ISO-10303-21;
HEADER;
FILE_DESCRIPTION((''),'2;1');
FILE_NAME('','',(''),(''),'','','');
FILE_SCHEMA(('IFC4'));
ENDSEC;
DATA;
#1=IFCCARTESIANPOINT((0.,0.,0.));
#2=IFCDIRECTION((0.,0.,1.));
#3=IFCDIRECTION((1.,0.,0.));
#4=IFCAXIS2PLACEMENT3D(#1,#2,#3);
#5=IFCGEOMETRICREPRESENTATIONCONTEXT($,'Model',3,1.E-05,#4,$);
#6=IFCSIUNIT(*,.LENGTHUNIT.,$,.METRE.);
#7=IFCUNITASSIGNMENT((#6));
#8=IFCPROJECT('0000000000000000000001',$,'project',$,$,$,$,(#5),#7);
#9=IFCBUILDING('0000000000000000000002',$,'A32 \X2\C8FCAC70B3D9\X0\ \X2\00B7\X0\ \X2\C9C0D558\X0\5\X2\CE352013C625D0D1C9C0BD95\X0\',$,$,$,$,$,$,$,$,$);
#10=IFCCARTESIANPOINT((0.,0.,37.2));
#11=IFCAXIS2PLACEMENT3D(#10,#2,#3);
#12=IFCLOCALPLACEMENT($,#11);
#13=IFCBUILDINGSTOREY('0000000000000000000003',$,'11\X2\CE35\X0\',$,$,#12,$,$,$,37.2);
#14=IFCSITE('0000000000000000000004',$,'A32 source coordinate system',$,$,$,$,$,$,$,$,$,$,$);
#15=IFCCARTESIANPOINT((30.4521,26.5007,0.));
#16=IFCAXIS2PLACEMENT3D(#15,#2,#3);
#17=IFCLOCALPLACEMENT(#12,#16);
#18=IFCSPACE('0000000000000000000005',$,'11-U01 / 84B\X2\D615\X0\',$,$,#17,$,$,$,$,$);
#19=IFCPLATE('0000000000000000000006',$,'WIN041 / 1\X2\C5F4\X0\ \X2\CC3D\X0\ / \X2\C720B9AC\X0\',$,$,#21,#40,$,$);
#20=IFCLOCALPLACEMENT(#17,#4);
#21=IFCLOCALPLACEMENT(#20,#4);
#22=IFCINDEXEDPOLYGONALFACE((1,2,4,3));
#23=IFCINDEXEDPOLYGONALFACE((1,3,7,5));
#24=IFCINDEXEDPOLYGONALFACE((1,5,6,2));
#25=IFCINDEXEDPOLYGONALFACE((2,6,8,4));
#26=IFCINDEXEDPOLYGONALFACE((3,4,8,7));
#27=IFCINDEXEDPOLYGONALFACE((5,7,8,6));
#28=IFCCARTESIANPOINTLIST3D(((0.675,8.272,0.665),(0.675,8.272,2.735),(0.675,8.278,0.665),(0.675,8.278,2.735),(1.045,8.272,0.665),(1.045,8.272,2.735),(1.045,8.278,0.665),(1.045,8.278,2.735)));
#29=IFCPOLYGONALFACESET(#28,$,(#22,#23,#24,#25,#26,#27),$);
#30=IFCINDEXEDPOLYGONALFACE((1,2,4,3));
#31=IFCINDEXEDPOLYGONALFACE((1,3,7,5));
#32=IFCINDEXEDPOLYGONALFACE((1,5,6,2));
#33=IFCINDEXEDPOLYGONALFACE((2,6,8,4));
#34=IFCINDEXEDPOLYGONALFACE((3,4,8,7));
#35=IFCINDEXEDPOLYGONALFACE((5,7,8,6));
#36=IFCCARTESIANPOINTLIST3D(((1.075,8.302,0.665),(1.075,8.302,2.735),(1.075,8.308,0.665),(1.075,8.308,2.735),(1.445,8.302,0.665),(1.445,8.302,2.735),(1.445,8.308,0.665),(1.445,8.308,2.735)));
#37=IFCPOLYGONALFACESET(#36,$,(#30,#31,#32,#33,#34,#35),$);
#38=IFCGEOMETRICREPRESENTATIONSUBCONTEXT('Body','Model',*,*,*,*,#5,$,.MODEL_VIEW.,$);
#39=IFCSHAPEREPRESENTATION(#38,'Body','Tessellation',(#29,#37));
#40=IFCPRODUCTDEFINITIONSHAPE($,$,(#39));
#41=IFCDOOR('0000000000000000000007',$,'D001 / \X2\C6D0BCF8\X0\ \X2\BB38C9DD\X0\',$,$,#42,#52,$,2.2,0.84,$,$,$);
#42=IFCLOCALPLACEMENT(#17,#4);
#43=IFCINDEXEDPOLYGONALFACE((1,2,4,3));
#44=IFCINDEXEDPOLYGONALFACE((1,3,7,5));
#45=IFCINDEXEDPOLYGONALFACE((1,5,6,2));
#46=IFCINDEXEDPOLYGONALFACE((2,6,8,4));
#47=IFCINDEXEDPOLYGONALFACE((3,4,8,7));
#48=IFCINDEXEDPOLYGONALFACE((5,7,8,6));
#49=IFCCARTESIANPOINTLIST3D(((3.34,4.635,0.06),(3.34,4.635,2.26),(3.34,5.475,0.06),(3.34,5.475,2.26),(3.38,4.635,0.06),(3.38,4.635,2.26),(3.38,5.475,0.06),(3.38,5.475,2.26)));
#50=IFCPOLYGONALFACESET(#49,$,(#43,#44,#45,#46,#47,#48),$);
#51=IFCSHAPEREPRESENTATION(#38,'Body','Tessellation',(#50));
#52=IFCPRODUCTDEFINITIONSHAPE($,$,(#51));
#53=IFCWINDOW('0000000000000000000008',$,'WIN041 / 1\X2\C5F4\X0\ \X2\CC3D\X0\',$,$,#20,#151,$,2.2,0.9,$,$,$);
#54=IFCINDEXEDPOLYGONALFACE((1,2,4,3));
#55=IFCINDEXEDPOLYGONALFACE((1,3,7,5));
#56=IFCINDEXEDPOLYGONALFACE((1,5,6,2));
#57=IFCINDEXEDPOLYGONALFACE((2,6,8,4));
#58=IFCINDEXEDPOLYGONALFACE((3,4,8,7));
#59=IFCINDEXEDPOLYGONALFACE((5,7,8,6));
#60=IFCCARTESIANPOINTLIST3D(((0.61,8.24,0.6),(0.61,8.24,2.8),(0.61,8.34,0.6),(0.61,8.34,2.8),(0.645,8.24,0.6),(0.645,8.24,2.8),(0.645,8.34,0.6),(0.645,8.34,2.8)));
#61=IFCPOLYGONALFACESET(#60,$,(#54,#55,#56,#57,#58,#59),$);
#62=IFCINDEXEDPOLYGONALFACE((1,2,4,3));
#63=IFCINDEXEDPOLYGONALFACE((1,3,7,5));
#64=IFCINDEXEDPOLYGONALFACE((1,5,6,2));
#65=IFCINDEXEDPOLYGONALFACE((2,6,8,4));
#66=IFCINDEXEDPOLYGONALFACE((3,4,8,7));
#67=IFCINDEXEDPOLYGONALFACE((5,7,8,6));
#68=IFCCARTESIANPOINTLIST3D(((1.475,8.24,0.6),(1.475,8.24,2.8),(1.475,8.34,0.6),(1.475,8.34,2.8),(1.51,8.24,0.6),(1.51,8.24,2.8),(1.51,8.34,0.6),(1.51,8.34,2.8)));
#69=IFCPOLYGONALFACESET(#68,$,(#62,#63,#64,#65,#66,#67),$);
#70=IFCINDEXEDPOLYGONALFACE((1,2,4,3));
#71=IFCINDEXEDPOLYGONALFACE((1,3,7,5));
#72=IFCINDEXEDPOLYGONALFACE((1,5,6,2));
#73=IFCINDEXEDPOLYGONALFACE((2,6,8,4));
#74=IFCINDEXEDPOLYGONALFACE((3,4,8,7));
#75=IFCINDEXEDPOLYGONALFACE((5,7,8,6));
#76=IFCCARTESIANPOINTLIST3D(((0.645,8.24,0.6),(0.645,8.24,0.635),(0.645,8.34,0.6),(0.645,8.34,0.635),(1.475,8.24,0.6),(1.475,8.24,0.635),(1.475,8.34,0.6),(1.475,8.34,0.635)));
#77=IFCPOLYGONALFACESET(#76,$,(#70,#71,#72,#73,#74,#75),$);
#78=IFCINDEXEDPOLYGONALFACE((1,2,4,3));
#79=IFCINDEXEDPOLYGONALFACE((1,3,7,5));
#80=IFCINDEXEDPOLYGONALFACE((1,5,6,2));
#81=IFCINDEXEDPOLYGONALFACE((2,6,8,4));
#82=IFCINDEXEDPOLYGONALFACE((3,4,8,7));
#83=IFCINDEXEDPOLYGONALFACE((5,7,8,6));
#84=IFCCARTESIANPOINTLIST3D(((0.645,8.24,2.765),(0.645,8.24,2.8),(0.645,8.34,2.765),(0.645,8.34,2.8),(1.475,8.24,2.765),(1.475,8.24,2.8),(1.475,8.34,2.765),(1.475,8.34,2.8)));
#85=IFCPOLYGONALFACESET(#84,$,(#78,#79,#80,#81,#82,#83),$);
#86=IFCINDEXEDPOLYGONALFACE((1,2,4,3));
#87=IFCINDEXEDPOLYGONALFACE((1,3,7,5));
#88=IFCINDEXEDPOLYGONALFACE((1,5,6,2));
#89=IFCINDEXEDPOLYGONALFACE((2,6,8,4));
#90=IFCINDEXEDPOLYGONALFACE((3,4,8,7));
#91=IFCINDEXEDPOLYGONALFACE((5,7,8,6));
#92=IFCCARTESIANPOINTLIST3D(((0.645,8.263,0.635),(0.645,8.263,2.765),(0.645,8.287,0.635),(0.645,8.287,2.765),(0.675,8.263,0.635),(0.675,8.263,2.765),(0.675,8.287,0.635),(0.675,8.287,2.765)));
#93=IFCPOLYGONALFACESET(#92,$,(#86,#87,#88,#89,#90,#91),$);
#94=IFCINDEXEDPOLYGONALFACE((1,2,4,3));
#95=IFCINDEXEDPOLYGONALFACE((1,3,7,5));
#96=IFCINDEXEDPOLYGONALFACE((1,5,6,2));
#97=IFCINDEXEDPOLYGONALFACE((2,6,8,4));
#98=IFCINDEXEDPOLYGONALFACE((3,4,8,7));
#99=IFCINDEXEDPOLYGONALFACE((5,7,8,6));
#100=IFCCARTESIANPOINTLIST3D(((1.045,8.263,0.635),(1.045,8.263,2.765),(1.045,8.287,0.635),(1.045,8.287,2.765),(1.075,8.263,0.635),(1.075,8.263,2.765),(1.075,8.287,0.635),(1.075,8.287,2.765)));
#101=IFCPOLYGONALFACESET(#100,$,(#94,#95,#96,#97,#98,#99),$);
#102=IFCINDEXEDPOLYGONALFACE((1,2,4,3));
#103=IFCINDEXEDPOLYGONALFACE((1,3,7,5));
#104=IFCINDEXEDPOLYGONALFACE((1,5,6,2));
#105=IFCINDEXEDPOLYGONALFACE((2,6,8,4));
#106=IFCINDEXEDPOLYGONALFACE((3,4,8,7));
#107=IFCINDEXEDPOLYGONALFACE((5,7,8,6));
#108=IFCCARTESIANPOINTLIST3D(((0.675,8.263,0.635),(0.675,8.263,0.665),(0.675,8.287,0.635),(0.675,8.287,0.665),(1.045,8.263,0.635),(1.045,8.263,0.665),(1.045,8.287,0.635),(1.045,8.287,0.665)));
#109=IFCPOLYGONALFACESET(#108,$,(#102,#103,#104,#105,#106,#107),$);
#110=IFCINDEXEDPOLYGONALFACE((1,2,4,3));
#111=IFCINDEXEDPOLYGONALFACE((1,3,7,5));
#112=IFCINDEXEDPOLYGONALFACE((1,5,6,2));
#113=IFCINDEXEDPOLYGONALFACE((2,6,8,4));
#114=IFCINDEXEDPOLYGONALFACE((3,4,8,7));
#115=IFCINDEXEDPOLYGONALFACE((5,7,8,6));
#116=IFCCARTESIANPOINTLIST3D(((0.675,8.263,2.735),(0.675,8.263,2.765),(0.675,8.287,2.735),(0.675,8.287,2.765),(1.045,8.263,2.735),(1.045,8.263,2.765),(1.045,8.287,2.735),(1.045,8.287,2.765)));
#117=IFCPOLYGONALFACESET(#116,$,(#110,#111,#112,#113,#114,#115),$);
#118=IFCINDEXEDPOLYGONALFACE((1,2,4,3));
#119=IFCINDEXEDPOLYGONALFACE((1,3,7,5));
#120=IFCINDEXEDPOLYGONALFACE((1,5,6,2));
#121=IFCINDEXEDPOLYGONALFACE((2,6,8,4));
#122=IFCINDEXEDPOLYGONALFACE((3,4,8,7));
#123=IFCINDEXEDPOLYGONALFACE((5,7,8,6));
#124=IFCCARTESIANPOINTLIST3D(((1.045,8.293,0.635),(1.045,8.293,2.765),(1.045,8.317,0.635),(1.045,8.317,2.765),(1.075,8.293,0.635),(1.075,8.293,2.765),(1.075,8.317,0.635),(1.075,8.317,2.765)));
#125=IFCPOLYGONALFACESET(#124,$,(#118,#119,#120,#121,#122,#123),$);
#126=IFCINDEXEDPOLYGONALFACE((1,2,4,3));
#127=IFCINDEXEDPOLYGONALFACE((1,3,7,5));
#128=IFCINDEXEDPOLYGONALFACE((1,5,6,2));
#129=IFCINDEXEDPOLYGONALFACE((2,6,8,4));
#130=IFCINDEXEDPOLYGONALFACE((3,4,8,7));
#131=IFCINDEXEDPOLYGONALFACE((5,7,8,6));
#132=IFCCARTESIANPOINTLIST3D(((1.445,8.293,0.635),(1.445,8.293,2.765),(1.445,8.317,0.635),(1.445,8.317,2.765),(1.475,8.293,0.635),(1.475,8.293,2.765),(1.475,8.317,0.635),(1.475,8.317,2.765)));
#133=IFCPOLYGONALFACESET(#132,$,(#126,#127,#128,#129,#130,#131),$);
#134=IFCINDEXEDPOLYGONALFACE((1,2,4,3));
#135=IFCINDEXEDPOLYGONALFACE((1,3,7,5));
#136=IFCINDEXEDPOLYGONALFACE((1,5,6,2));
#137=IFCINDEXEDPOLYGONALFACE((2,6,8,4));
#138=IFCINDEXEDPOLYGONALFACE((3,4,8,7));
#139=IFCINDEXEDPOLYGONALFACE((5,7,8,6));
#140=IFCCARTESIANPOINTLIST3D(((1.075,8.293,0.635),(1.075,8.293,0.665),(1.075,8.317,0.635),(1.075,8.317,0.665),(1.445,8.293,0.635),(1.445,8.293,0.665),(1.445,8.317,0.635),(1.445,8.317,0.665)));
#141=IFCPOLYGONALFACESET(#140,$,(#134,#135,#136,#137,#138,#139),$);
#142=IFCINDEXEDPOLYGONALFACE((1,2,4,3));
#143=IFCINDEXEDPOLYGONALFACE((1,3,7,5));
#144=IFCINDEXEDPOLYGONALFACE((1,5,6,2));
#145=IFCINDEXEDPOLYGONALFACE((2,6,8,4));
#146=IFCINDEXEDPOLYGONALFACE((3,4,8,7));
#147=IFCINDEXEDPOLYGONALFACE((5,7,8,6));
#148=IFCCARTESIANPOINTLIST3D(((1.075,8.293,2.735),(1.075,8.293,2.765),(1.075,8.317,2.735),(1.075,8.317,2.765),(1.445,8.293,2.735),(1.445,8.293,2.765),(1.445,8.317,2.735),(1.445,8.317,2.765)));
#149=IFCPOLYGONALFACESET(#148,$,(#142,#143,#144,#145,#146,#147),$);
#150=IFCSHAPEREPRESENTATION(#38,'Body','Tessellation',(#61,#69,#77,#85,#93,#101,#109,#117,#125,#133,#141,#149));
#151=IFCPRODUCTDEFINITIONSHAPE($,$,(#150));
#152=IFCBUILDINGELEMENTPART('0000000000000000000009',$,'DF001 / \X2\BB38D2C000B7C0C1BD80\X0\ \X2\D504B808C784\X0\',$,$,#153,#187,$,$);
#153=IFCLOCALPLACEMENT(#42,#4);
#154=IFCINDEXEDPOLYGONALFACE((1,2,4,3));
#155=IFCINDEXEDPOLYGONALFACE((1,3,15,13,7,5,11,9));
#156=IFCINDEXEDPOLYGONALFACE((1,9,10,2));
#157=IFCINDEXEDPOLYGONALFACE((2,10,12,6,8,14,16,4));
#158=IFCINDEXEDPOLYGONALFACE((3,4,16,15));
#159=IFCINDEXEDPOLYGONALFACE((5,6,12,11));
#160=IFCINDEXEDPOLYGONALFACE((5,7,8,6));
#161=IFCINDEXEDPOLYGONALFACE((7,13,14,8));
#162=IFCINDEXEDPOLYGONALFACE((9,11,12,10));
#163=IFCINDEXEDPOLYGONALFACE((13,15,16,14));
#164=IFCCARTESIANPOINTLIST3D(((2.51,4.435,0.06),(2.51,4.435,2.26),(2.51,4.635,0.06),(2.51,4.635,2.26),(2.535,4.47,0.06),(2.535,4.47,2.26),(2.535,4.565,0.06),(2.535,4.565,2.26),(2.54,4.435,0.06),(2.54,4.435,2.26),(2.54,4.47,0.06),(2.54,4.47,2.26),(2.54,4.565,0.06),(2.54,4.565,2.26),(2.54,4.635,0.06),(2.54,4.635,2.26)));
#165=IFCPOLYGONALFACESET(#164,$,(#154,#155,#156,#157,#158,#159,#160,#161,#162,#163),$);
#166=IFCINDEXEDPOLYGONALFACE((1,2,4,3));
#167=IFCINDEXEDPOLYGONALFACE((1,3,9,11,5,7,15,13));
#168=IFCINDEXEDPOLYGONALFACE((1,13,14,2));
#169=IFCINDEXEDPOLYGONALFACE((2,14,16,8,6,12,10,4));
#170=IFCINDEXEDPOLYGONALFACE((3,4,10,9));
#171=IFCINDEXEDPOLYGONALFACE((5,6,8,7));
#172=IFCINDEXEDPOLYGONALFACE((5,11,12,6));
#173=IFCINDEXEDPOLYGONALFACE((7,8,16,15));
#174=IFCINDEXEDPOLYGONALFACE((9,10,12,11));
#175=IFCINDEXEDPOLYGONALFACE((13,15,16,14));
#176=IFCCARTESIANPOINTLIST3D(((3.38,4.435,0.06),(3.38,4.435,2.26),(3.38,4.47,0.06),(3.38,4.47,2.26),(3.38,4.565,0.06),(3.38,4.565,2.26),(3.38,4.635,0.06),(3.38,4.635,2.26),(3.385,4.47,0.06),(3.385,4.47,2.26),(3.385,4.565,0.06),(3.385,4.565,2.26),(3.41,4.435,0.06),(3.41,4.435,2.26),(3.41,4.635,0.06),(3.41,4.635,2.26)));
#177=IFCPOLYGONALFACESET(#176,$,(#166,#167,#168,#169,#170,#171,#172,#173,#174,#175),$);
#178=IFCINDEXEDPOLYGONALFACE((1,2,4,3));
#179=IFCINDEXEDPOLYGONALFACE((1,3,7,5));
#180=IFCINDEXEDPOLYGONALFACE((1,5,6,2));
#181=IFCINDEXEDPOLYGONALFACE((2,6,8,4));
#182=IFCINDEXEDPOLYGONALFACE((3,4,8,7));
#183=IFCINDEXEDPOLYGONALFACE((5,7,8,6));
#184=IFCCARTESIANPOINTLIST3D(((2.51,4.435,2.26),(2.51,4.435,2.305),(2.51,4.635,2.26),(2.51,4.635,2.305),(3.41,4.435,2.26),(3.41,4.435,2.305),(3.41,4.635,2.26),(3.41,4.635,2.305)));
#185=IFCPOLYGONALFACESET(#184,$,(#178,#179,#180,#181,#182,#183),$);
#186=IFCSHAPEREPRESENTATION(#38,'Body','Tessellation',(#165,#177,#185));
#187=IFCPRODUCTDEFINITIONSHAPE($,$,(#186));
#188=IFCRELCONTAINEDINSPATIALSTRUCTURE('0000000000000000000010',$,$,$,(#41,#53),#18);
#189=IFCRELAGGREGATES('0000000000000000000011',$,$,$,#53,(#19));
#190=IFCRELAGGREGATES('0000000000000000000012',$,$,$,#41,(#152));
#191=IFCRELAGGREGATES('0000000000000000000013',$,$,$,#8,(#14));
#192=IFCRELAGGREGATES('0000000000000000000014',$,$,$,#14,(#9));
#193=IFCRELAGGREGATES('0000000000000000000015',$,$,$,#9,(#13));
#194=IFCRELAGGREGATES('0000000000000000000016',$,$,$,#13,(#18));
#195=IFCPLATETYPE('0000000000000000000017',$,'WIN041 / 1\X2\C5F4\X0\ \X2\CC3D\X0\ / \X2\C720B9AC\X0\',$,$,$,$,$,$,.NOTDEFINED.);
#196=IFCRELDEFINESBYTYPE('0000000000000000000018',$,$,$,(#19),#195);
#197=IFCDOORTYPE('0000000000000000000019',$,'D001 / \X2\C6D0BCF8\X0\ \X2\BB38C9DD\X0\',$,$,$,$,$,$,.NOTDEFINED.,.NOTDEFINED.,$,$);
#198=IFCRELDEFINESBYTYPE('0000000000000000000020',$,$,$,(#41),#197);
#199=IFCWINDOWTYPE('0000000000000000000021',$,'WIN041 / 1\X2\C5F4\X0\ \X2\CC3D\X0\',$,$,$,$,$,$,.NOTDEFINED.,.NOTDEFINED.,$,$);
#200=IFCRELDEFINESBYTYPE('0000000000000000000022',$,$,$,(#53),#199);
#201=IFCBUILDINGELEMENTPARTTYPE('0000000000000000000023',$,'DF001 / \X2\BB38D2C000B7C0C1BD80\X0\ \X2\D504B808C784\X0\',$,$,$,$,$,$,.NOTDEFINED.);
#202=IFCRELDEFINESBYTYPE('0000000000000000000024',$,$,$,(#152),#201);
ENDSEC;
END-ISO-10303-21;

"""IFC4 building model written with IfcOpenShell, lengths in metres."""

from ifc_helpers import new_model, si_unit, frame, origin, origin_with_axes, place, context, subcontext, project, spatial, polyline, outline, extrude, source, transform, mapped, type_object, type_shapes, element, aggregate, save


model = new_model("IFC4")

# Units and contexts
model_context = context("Model", 3, precision=1e-05, world=origin_with_axes())
body_context = subcontext(model_context, "Body", "Model", "MODEL_VIEW")
ifc_project = project(units=[si_unit("LENGTHUNIT", "METRE")], contexts=[model_context])

# Plate
storey_placement = place(None, frame((0.0, 0.0, 37.2), z_axis=(0.0, 0.0, 1.0), x_axis=(1.0, 0.0, 0.0)))
space_placement = place(storey_placement, frame((30.4521, 26.5007, 0.0), z_axis=(0.0, 0.0, 1.0), x_axis=(1.0, 0.0, 0.0)))
plate_type_1 = type_object("IfcPlateType", Name="WIN041 / 1열 창 / 유리", PredefinedType="NOTDEFINED")
shared_shape_1 = source(origin(), body_context, "Body", "SweptSolid", [
    extrude(outline(polyline([(0.675, 8.272), (0.675, 8.278), (1.045, 8.278), (1.045, 8.272), (0.675, 8.272)])), frame((0.0, 0.0, 0.665)), (0.0, 0.0, 1.0), 2.07),
    extrude(outline(polyline([(1.075, 8.302), (1.075, 8.308), (1.445, 8.308), (1.445, 8.302), (1.075, 8.302)])), frame((0.0, 0.0, 0.665)), (0.0, 0.0, 1.0), 2.07),
])
type_shapes(plate_type_1, [shared_shape_1])
window_1_placement = place(space_placement, origin_with_axes())
plate_1_placement = place(window_1_placement, origin_with_axes())
plate_1 = element("IfcPlate", 1, at=plate_1_placement, type_object=plate_type_1, Name="WIN041 / 1열 창 / 유리", context=body_context, shape_type="MappedRepresentation", body=[
    mapped(shared_shape_1, transform((0.0, 0.0, 0.0), scale=1.0)),
])

# Site, building, storey, space
site = spatial("IfcSite", under=ifc_project, Name="A32 source coordinate system")
building = spatial("IfcBuilding", under=site, Name="A32 주거동 · 지하5층–옥탑지붕")
storey = spatial("IfcBuildingStorey", under=building, at=storey_placement, Name="11층", Elevation=37.2)
space = spatial("IfcSpace", under=storey, at=space_placement, Name="11-U01 / 84B형")

# Door
door_type_1 = type_object("IfcDoorType", Name="D001 / 원본 문짝", OperationType="NOTDEFINED", PredefinedType="NOTDEFINED")
shared_shape_2 = source(origin(), body_context, "Body", "SweptSolid", [
    extrude(outline(polyline([(3.34, 5.475), (3.38, 5.475), (3.38, 4.635), (3.34, 4.635), (3.34, 5.475)])), frame((0.0, 0.0, 0.06)), (0.0, 0.0, 1.0), 2.2),
])
type_shapes(door_type_1, [shared_shape_2])
door_1_placement = place(space_placement, origin_with_axes())
door_1 = element("IfcDoor", 2, at=door_1_placement, inside=space, type_object=door_type_1, Name="D001 / 원본 문짝", OverallHeight=2.2, OverallWidth=0.84, context=body_context, shape_type="MappedRepresentation", body=[
    mapped(shared_shape_2, transform((0.0, 0.0, 0.0), scale=1.0)),
])

# Window
window_type_1 = type_object("IfcWindowType", Name="WIN041 / 1열 창", PartitioningType="NOTDEFINED", PredefinedType="NOTDEFINED")
shared_shape_3 = source(origin(), body_context, "Body", "SweptSolid", [
    extrude(outline(polyline([(0.61, 8.24), (0.61, 8.34), (0.645, 8.34), (0.645, 8.24), (0.61, 8.24)])), frame((0.0, 0.0, 0.6)), (0.0, 0.0, 1.0), 2.2),
    extrude(outline(polyline([(1.475, 8.24), (1.475, 8.34), (1.51, 8.34), (1.51, 8.24), (1.475, 8.24)])), frame((0.0, 0.0, 0.6)), (0.0, 0.0, 1.0), 2.2),
    extrude(outline(polyline([(0.645, 8.24), (0.645, 8.34), (1.475, 8.34), (1.475, 8.24), (0.645, 8.24)])), frame((0.0, 0.0, 0.6)), (0.0, 0.0, 1.0), 0.035),
    extrude(outline(polyline([(0.645, 8.24), (0.645, 8.34), (1.475, 8.34), (1.475, 8.24), (0.645, 8.24)])), frame((0.0, 0.0, 2.765)), (0.0, 0.0, 1.0), 0.035),
    extrude(outline(polyline([(0.645, 8.263), (0.645, 8.287), (0.675, 8.287), (0.675, 8.263), (0.645, 8.263)])), frame((0.0, 0.0, 0.635)), (0.0, 0.0, 1.0), 2.13),
    extrude(outline(polyline([(1.045, 8.263), (1.045, 8.287), (1.075, 8.287), (1.075, 8.263), (1.045, 8.263)])), frame((0.0, 0.0, 0.635)), (0.0, 0.0, 1.0), 2.13),
    extrude(outline(polyline([(0.675, 8.263), (0.675, 8.287), (1.045, 8.287), (1.045, 8.263), (0.675, 8.263)])), frame((0.0, 0.0, 0.635)), (0.0, 0.0, 1.0), 0.03),
    extrude(outline(polyline([(0.675, 8.263), (0.675, 8.287), (1.045, 8.287), (1.045, 8.263), (0.675, 8.263)])), frame((0.0, 0.0, 2.735)), (0.0, 0.0, 1.0), 0.03),
    extrude(outline(polyline([(1.045, 8.293), (1.045, 8.317), (1.075, 8.317), (1.075, 8.293), (1.045, 8.293)])), frame((0.0, 0.0, 0.635)), (0.0, 0.0, 1.0), 2.13),
    extrude(outline(polyline([(1.445, 8.293), (1.445, 8.317), (1.475, 8.317), (1.475, 8.293), (1.445, 8.293)])), frame((0.0, 0.0, 0.635)), (0.0, 0.0, 1.0), 2.13),
    extrude(outline(polyline([(1.075, 8.293), (1.075, 8.317), (1.445, 8.317), (1.445, 8.293), (1.075, 8.293)])), frame((0.0, 0.0, 0.635)), (0.0, 0.0, 1.0), 0.03),
    extrude(outline(polyline([(1.075, 8.293), (1.075, 8.317), (1.445, 8.317), (1.445, 8.293), (1.075, 8.293)])), frame((0.0, 0.0, 2.735)), (0.0, 0.0, 1.0), 0.03),
])
type_shapes(window_type_1, [shared_shape_3])
window_1 = element("IfcWindow", 3, at=window_1_placement, inside=space, type_object=window_type_1, Name="WIN041 / 1열 창", OverallHeight=2.2, OverallWidth=0.9, context=body_context, shape_type="MappedRepresentation", body=[
    mapped(shared_shape_3, transform((0.0, 0.0, 0.0), scale=1.0)),
])
aggregate(window_1, [plate_1])

# Building element part
building_element_part_type_1 = type_object("IfcBuildingElementPartType", Name="DF001 / 문틀·상부 프레임", PredefinedType="NOTDEFINED")
shared_shape_4 = source(origin(), body_context, "Body", "SweptSolid", [
    extrude(outline(polyline([(2.54, 4.635), (2.54, 4.565), (2.535, 4.565), (2.535, 4.47), (2.54, 4.47), (2.54, 4.435), (2.51, 4.435), (2.51, 4.635), (2.54, 4.635)])), frame((0.0, 0.0, 0.06)), (0.0, 0.0, 1.0), 2.2),
    extrude(outline(polyline([(3.41, 4.435), (3.38, 4.435), (3.38, 4.47), (3.385, 4.47), (3.385, 4.565), (3.38, 4.565), (3.38, 4.635), (3.41, 4.635), (3.41, 4.435)])), frame((0.0, 0.0, 0.06)), (0.0, 0.0, 1.0), 2.2),
    extrude(outline(polyline([(2.51, 4.435), (2.51, 4.635), (3.41, 4.635), (3.41, 4.435), (2.51, 4.435)])), frame((0.0, 0.0, 2.26)), (0.0, 0.0, 1.0), 0.045),
])
type_shapes(building_element_part_type_1, [shared_shape_4])
building_element_part_1_placement = place(door_1_placement, origin_with_axes())
building_element_part_1 = element("IfcBuildingElementPart", 4, at=building_element_part_1_placement, type_object=building_element_part_type_1, Name="DF001 / 문틀·상부 프레임", context=body_context, shape_type="MappedRepresentation", body=[
    mapped(shared_shape_4, transform((0.0, 0.0, 0.0), scale=1.0)),
])
aggregate(door_1, [building_element_part_1])

save(model, "model.ifc")
